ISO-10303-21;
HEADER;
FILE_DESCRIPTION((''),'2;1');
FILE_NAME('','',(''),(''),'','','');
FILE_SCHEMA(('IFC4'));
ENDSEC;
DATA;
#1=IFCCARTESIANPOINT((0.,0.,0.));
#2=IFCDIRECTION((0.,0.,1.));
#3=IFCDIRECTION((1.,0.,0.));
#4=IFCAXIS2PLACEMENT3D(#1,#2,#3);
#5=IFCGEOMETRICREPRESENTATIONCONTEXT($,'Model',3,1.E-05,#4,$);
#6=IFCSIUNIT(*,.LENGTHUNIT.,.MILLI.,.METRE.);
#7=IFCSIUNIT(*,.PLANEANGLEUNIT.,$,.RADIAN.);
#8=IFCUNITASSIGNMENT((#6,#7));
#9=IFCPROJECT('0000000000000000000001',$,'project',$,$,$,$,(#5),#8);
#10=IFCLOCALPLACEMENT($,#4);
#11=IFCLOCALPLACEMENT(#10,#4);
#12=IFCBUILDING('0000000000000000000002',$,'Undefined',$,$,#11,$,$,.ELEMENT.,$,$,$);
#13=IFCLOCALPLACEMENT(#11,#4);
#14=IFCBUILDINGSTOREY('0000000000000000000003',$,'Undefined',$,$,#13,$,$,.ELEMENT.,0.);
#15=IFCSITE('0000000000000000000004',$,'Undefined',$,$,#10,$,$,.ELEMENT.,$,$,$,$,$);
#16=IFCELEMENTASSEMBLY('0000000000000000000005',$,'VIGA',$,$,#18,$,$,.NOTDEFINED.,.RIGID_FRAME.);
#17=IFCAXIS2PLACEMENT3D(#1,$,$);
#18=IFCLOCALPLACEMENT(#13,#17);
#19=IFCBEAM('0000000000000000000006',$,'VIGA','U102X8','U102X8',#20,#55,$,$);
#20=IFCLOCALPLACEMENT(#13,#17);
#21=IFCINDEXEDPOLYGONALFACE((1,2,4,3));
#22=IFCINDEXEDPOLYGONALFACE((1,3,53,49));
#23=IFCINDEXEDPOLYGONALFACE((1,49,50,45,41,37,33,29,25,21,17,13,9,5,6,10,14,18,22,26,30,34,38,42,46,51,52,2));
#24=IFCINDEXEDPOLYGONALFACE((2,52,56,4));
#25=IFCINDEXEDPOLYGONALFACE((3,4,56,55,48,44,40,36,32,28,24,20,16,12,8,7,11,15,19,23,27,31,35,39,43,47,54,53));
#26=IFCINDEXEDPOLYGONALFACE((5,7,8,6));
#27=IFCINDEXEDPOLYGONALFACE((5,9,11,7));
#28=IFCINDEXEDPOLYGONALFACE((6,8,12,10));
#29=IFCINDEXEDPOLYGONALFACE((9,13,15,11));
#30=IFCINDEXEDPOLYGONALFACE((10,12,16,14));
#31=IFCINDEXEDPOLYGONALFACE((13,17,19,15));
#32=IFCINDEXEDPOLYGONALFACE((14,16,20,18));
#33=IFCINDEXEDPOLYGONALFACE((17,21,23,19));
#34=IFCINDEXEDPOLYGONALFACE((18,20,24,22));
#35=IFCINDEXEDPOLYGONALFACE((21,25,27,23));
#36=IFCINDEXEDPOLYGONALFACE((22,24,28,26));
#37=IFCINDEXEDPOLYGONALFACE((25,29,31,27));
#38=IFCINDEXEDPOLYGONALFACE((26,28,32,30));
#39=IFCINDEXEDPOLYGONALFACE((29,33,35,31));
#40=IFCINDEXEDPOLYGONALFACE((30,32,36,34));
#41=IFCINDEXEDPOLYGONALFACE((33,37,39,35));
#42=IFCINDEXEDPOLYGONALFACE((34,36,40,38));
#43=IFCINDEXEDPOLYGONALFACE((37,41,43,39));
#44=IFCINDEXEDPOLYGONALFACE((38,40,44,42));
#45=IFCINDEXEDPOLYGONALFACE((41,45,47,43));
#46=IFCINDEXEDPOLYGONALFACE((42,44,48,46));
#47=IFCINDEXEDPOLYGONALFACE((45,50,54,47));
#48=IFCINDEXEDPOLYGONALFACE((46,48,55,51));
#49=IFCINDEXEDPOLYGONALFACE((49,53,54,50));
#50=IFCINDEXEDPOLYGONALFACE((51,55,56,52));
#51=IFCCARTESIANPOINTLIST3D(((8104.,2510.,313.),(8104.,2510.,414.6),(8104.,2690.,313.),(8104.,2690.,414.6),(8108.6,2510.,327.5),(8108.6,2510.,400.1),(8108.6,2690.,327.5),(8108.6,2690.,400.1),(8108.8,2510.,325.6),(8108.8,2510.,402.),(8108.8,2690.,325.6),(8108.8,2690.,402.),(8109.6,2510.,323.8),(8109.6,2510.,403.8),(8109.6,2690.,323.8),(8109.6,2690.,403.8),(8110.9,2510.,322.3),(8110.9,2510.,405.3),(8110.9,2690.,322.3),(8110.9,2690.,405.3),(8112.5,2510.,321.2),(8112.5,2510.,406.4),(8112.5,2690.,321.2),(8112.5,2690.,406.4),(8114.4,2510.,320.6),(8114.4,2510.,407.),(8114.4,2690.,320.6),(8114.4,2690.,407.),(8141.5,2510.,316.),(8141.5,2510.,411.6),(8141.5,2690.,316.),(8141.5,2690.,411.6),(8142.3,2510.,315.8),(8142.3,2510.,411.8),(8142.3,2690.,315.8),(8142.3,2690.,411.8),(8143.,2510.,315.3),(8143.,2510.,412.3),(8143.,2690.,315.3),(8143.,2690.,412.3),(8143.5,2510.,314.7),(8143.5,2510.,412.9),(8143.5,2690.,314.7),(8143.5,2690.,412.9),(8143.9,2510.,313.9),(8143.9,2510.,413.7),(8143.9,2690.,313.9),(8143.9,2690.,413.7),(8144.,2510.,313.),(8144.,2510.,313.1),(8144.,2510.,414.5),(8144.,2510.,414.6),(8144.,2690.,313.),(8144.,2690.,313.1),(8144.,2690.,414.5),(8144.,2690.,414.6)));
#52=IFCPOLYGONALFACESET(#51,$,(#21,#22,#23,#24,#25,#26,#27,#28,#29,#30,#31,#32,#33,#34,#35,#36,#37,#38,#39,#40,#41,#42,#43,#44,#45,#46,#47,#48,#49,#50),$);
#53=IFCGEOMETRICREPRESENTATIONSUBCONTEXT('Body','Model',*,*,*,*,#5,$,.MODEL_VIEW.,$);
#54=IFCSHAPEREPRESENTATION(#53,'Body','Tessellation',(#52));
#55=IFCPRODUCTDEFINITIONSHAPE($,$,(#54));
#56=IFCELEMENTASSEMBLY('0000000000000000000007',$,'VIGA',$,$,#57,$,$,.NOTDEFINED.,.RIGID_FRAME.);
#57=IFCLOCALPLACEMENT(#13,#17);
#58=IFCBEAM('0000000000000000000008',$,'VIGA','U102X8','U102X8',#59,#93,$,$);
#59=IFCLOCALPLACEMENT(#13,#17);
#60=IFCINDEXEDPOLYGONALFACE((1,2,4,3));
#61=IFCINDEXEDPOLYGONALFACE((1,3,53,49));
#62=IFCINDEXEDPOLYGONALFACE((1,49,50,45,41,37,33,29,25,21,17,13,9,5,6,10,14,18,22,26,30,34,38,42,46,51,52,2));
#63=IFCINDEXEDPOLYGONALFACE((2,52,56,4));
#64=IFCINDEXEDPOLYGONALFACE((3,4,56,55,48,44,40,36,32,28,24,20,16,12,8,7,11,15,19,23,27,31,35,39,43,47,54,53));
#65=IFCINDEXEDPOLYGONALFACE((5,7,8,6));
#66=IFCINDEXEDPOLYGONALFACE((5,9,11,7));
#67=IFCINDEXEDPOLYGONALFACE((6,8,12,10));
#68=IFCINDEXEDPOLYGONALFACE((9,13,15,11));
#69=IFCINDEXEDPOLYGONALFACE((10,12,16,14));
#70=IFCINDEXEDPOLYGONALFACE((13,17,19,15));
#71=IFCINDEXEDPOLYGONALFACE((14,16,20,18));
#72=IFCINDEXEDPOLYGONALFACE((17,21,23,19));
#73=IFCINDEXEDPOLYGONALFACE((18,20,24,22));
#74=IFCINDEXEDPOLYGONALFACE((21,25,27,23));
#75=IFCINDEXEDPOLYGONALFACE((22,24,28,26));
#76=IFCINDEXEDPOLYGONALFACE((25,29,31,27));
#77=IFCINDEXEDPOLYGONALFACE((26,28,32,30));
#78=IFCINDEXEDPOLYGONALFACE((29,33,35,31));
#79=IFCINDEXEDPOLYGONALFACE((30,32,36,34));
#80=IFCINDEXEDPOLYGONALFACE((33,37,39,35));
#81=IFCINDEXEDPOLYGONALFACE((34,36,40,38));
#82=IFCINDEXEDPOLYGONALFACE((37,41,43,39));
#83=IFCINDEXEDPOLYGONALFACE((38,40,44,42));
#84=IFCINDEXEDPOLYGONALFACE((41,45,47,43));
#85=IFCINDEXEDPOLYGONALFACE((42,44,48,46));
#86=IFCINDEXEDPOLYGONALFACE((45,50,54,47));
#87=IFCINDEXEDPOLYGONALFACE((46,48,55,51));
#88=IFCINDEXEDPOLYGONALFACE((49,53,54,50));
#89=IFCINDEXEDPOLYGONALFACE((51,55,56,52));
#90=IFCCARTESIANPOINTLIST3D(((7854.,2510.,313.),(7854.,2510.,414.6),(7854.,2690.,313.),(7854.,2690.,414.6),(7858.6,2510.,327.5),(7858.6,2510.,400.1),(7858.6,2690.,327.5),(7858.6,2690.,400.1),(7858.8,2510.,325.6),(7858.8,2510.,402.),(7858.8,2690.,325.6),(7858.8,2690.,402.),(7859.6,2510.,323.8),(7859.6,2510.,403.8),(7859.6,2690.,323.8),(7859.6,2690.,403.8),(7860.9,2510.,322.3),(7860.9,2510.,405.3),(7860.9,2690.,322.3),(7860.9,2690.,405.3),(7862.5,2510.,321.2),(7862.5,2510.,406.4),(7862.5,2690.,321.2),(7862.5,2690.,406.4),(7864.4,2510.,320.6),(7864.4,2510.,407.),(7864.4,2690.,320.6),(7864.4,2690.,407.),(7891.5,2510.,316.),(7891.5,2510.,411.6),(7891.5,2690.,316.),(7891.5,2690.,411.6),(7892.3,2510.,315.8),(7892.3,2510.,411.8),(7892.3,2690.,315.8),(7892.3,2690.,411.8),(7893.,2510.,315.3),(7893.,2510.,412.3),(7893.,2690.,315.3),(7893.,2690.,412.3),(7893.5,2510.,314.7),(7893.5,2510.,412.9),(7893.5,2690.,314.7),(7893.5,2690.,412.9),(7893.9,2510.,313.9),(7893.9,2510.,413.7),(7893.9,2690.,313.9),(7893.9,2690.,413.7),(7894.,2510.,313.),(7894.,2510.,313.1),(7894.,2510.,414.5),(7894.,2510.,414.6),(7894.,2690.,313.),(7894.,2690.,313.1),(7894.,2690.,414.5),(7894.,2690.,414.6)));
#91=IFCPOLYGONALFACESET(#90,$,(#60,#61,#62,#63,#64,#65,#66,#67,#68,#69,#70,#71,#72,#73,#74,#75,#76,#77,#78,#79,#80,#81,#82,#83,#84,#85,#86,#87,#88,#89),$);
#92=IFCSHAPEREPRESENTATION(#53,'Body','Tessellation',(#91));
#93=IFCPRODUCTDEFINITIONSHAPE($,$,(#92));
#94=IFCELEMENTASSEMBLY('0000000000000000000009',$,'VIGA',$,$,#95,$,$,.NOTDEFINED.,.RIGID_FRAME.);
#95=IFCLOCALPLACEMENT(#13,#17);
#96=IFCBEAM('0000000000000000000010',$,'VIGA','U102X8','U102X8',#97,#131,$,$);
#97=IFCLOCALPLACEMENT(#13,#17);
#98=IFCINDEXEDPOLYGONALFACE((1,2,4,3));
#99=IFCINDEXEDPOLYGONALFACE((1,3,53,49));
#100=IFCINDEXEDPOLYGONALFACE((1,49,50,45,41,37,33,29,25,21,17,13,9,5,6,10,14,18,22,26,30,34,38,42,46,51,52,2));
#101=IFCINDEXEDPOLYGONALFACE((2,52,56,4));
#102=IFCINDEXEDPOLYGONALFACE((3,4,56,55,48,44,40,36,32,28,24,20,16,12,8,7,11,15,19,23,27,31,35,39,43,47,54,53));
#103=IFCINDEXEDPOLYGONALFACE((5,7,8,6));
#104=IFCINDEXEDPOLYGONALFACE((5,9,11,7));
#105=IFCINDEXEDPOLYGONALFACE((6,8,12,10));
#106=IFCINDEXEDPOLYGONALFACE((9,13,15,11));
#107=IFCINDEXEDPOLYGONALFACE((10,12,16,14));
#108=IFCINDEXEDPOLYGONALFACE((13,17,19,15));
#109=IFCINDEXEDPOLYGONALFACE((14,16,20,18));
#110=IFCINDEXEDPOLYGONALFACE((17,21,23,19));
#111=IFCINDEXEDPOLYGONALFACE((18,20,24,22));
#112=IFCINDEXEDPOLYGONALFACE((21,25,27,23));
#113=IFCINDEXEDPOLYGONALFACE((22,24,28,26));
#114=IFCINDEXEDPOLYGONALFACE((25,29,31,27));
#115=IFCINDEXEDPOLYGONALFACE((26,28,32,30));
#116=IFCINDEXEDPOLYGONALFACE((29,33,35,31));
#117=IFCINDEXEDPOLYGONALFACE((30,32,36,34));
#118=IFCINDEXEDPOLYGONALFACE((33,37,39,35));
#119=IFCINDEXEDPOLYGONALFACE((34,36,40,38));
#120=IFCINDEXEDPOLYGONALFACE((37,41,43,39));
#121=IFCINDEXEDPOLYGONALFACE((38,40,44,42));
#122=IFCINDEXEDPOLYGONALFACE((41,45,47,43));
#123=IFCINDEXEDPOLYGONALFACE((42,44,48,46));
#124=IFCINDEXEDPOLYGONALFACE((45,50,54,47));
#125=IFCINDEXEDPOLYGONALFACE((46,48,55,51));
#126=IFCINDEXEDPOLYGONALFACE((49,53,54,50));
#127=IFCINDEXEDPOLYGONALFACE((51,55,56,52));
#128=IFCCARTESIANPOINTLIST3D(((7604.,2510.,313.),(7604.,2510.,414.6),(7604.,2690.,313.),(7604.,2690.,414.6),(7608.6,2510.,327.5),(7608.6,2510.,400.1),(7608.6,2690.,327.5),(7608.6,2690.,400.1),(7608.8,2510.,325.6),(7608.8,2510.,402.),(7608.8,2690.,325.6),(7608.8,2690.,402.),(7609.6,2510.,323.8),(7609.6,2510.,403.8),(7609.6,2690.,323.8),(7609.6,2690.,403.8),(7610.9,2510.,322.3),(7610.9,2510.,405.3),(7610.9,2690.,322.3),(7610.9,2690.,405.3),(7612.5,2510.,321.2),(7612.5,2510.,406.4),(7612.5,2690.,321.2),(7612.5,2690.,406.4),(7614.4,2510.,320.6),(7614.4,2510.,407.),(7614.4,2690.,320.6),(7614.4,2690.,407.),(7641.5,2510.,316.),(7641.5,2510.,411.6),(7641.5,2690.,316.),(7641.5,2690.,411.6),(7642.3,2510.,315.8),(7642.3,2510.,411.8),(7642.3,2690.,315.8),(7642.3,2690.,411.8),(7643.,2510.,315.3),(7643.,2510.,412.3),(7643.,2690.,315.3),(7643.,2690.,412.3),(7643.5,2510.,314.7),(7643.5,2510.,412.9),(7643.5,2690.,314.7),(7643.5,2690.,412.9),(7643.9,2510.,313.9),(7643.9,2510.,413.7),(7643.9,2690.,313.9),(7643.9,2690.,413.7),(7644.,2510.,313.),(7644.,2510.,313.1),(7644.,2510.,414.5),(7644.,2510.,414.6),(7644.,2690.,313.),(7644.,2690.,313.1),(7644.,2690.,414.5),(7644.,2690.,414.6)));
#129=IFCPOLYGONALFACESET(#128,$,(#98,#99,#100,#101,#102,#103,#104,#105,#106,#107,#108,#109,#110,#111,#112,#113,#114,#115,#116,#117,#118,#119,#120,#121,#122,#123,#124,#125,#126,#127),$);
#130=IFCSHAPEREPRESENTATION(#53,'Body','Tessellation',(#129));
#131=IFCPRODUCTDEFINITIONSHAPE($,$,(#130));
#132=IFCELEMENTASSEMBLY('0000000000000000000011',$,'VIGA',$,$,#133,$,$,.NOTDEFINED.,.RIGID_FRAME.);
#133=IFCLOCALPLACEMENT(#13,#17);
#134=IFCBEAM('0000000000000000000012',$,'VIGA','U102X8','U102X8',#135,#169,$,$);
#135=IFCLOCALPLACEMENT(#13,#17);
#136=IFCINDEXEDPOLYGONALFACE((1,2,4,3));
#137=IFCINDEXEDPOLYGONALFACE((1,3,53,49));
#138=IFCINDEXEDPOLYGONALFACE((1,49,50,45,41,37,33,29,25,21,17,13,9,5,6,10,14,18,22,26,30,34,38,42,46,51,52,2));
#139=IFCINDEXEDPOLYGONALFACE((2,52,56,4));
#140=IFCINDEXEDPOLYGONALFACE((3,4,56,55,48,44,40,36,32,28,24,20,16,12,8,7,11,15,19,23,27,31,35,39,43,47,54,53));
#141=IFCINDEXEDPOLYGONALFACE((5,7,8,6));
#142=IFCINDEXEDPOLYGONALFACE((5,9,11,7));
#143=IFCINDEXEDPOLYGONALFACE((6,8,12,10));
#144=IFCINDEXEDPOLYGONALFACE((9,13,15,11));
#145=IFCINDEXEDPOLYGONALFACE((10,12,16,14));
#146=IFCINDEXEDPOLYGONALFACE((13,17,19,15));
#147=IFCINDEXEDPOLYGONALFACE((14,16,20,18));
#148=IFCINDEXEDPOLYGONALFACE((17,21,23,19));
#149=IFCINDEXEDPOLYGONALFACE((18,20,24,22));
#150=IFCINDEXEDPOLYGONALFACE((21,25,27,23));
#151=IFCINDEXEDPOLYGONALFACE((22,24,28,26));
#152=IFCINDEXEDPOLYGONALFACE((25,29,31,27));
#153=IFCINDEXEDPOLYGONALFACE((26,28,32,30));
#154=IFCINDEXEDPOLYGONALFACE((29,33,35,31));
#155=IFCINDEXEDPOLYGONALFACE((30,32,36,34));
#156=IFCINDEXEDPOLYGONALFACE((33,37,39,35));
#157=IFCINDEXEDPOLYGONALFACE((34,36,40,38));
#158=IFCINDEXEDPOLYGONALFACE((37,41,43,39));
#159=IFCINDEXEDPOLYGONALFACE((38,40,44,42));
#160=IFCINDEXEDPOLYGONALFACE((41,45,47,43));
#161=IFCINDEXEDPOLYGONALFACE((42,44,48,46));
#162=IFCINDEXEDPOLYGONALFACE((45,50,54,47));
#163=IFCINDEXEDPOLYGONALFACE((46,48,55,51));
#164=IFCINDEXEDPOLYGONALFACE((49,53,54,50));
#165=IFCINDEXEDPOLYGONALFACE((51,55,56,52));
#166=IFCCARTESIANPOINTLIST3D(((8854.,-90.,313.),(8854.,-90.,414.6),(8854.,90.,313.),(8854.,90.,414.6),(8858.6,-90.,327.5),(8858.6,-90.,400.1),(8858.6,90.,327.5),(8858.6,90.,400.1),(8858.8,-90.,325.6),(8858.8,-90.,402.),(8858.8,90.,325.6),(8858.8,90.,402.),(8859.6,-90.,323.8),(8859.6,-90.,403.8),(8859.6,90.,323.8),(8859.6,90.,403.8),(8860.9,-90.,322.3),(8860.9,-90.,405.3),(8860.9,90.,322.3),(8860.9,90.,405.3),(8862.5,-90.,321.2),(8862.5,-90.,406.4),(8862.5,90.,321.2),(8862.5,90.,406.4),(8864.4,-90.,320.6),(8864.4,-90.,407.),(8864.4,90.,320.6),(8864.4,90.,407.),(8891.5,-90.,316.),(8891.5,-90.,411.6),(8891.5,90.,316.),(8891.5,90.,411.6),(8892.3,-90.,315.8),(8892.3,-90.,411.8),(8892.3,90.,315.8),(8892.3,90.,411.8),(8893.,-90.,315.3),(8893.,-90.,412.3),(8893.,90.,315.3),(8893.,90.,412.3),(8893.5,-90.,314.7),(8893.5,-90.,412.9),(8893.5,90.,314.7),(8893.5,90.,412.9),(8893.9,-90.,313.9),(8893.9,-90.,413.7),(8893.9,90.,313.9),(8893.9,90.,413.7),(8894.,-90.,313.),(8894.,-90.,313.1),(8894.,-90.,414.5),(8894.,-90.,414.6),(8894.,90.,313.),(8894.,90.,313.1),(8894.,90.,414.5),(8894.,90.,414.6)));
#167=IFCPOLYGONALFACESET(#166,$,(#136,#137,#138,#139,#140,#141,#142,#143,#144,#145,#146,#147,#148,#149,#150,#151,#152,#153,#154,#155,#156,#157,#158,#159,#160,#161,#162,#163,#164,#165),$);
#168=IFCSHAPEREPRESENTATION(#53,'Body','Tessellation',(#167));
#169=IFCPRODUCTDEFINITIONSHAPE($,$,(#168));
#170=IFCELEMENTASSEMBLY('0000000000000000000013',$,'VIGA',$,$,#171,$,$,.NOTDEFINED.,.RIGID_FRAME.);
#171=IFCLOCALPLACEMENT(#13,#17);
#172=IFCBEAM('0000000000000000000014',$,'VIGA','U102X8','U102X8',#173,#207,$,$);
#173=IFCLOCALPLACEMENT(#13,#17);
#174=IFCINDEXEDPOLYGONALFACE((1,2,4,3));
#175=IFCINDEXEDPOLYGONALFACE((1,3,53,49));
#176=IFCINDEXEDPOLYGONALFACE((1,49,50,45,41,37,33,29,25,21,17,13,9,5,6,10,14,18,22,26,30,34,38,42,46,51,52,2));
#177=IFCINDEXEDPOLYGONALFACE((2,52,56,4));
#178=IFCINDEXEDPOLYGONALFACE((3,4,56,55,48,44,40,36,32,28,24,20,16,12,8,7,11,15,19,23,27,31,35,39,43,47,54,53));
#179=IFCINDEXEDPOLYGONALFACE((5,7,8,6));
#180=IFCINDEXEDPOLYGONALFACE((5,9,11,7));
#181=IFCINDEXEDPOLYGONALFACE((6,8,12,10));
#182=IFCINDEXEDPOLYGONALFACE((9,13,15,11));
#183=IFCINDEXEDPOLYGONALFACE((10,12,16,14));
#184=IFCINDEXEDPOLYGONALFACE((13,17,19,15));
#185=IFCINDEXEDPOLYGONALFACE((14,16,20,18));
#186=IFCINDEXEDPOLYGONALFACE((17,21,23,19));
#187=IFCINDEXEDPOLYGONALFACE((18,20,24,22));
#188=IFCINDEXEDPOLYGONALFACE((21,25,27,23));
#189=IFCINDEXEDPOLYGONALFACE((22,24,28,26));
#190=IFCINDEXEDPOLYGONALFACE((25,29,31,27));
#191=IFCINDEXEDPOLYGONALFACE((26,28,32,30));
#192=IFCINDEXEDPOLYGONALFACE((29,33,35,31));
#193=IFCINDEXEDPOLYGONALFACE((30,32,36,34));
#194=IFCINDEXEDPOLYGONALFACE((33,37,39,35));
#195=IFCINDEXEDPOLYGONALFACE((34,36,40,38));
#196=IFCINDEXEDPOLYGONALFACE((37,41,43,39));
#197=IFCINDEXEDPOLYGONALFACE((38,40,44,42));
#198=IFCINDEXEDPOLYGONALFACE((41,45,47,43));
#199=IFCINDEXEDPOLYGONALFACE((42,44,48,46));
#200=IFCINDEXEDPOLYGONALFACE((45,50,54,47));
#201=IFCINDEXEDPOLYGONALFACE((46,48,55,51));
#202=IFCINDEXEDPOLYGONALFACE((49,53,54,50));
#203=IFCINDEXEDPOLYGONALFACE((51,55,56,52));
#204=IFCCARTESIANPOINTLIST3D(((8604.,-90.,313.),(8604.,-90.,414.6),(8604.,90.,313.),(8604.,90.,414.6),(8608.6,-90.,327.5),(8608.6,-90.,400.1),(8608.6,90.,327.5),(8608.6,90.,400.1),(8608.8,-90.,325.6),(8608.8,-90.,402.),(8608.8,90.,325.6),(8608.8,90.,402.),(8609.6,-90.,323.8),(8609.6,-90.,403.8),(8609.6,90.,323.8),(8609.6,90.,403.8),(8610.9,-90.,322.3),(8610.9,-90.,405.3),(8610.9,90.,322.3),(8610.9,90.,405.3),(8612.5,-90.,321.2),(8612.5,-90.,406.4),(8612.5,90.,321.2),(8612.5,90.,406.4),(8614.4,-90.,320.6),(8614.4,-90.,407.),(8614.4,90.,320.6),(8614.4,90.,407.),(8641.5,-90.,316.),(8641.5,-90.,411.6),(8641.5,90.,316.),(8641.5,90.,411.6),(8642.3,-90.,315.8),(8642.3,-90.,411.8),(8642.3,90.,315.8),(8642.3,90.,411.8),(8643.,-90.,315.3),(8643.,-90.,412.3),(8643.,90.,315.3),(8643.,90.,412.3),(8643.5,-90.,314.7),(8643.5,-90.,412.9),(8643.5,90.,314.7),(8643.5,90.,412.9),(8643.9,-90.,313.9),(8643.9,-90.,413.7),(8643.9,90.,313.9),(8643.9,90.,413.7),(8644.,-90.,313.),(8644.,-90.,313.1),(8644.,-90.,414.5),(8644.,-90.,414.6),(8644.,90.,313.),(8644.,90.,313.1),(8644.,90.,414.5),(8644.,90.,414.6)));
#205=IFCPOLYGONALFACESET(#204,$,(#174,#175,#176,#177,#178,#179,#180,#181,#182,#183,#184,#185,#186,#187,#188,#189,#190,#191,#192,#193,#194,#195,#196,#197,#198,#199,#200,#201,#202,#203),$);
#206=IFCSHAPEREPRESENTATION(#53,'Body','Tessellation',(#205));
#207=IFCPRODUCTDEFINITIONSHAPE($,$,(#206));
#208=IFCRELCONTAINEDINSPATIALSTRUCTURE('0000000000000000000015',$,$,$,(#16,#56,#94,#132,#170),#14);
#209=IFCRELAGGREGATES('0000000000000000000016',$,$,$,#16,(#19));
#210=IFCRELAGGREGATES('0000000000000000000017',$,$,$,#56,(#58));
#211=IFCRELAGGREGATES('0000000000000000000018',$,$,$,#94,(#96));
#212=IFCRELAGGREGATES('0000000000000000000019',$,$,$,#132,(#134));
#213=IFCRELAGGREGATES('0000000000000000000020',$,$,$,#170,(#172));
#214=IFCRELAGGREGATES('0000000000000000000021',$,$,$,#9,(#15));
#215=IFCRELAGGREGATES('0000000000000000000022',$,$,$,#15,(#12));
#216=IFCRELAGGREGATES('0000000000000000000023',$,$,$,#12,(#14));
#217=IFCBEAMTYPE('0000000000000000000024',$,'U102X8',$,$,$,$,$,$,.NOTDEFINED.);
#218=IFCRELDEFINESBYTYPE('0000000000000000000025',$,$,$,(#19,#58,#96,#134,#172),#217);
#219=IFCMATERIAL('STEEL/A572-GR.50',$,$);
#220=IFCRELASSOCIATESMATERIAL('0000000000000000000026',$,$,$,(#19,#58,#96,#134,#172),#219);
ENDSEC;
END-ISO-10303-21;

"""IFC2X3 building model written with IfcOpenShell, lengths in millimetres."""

from ifc_helpers import new_model, si_unit, frame, origin_with_axes, origin_2d_with_axis, place, context, subcontext, project, spatial, u_section, extrude, material, type_object, element, aggregate, save


model = new_model("IFC2X3")

# Units and contexts
model_context = context("Model", 3, precision=1e-05, world=origin_with_axes())
body_context = subcontext(model_context, "Body", "Model", "MODEL_VIEW")
ifc_project = project(units=[si_unit("LENGTHUNIT", "METRE", prefix="MILLI"), si_unit("PLANEANGLEUNIT", "RADIAN")], contexts=[model_context])

# Site, building, storey
site_placement = place(None, origin_with_axes())
site = spatial("IfcSite", under=ifc_project, at=site_placement, Name="Undefined", CompositionType="ELEMENT")
building_placement = place(site_placement, origin_with_axes())
building = spatial("IfcBuilding", under=site, at=building_placement, Name="Undefined", CompositionType="ELEMENT")
storey_placement = place(building_placement, origin_with_axes())
storey = spatial("IfcBuildingStorey", under=building, at=storey_placement, Name="Undefined", CompositionType="ELEMENT", Elevation=0.0)

# Element assemblies, beams
ifc_material_1 = material(Name="STEEL/A572-GR.50")
beam_type_1 = type_object("IfcBeamType", Name="U102X8", PredefinedType="NOTDEFINED")
assembly_1_placement = place(storey_placement, origin_with_axes())
assembly_1 = element("IfcElementAssembly", 1, at=assembly_1_placement, inside=storey, Name="VIGA", AssemblyPlace="NOTDEFINED", PredefinedType="RIGID_FRAME")
beam_1_placement = place(assembly_1_placement, frame((8124.0, 2510.0, 363.8), z_axis=(0.0, 0.0, 1.0), x_axis=(0.0, 1.0, 0.0)))
beam_1 = element("IfcBeam", 2, at=beam_1_placement, type_object=beam_type_1, material=ifc_material_1, Name="VIGA", Description="U102X8", ObjectType="U102X8", context=body_context, shape_type="SweptSolid", body=[
    extrude(u_section(Depth=101.6, FlangeWidth=40.0, WebThickness=4.6, FlangeThickness=6.0, FilletRadius=7.0, EdgeRadius=3.0, FlangeSlope=0.16839, at=origin_2d_with_axis()), frame((180.0, 0.0, 0.0), z_axis=(-1.0, 0.0, 0.0), x_axis=(0.0, -1.0, 0.0)), (0.0, 0.0, 1.0), 180.0),
])
aggregate(assembly_1, [beam_1])
assembly_2_placement = place(storey_placement, origin_with_axes())
assembly_2 = element("IfcElementAssembly", 3, at=assembly_2_placement, inside=storey, Name="VIGA", AssemblyPlace="NOTDEFINED", PredefinedType="RIGID_FRAME")
beam_2_placement = place(assembly_2_placement, frame((7874.0, 2510.0, 363.8), z_axis=(0.0, 0.0, 1.0), x_axis=(0.0, 1.0, 0.0)))
beam_2 = element("IfcBeam", 4, at=beam_2_placement, type_object=beam_type_1, material=ifc_material_1, Name="VIGA", Description="U102X8", ObjectType="U102X8", context=body_context, shape_type="SweptSolid", body=[
    extrude(u_section(Depth=101.6, FlangeWidth=40.0, WebThickness=4.6, FlangeThickness=6.0, FilletRadius=7.0, EdgeRadius=3.0, FlangeSlope=0.16839, at=origin_2d_with_axis()), frame((180.0, 0.0, 0.0), z_axis=(-1.0, 0.0, 0.0), x_axis=(0.0, -1.0, 0.0)), (0.0, 0.0, 1.0), 180.0),
])
aggregate(assembly_2, [beam_2])
assembly_3_placement = place(storey_placement, origin_with_axes())
assembly_3 = element("IfcElementAssembly", 5, at=assembly_3_placement, inside=storey, Name="VIGA", AssemblyPlace="NOTDEFINED", PredefinedType="RIGID_FRAME")
beam_3_placement = place(assembly_3_placement, frame((7624.0, 2510.0, 363.8), z_axis=(0.0, 0.0, 1.0), x_axis=(0.0, 1.0, 0.0)))
beam_3 = element("IfcBeam", 6, at=beam_3_placement, type_object=beam_type_1, material=ifc_material_1, Name="VIGA", Description="U102X8", ObjectType="U102X8", context=body_context, shape_type="SweptSolid", body=[
    extrude(u_section(Depth=101.6, FlangeWidth=40.0, WebThickness=4.6, FlangeThickness=6.0, FilletRadius=7.0, EdgeRadius=3.0, FlangeSlope=0.16839, at=origin_2d_with_axis()), frame((180.0, 0.0, 0.0), z_axis=(-1.0, 0.0, 0.0), x_axis=(0.0, -1.0, 0.0)), (0.0, 0.0, 1.0), 180.0),
])
aggregate(assembly_3, [beam_3])
assembly_4_placement = place(storey_placement, origin_with_axes())
assembly_4 = element("IfcElementAssembly", 7, at=assembly_4_placement, inside=storey, Name="VIGA", AssemblyPlace="NOTDEFINED", PredefinedType="RIGID_FRAME")
beam_4_placement = place(assembly_4_placement, frame((8874.0, -90.0, 363.8), z_axis=(0.0, 0.0, 1.0), x_axis=(0.0, 1.0, 0.0)))
beam_4 = element("IfcBeam", 8, at=beam_4_placement, type_object=beam_type_1, material=ifc_material_1, Name="VIGA", Description="U102X8", ObjectType="U102X8", context=body_context, shape_type="SweptSolid", body=[
    extrude(u_section(Depth=101.6, FlangeWidth=40.0, WebThickness=4.6, FlangeThickness=6.0, FilletRadius=7.0, EdgeRadius=3.0, FlangeSlope=0.16839, at=origin_2d_with_axis()), frame((180.0, 0.0, 0.0), z_axis=(-1.0, 0.0, 0.0), x_axis=(0.0, -1.0, 0.0)), (0.0, 0.0, 1.0), 180.0),
])
aggregate(assembly_4, [beam_4])
assembly_5_placement = place(storey_placement, origin_with_axes())
assembly_5 = element("IfcElementAssembly", 9, at=assembly_5_placement, inside=storey, Name="VIGA", AssemblyPlace="NOTDEFINED", PredefinedType="RIGID_FRAME")
beam_5_placement = place(assembly_5_placement, frame((8624.0, -90.0, 363.8), z_axis=(0.0, 0.0, 1.0), x_axis=(0.0, 1.0, 0.0)))
beam_5 = element("IfcBeam", 10, at=beam_5_placement, type_object=beam_type_1, material=ifc_material_1, Name="VIGA", Description="U102X8", ObjectType="U102X8", context=body_context, shape_type="SweptSolid", body=[
    extrude(u_section(Depth=101.6, FlangeWidth=40.0, WebThickness=4.6, FlangeThickness=6.0, FilletRadius=7.0, EdgeRadius=3.0, FlangeSlope=0.16839, at=origin_2d_with_axis()), frame((180.0, 0.0, 0.0), z_axis=(-1.0, 0.0, 0.0), x_axis=(0.0, -1.0, 0.0)), (0.0, 0.0, 1.0), 180.0),
])
aggregate(assembly_5, [beam_5])

save(model, "model.ifc")
